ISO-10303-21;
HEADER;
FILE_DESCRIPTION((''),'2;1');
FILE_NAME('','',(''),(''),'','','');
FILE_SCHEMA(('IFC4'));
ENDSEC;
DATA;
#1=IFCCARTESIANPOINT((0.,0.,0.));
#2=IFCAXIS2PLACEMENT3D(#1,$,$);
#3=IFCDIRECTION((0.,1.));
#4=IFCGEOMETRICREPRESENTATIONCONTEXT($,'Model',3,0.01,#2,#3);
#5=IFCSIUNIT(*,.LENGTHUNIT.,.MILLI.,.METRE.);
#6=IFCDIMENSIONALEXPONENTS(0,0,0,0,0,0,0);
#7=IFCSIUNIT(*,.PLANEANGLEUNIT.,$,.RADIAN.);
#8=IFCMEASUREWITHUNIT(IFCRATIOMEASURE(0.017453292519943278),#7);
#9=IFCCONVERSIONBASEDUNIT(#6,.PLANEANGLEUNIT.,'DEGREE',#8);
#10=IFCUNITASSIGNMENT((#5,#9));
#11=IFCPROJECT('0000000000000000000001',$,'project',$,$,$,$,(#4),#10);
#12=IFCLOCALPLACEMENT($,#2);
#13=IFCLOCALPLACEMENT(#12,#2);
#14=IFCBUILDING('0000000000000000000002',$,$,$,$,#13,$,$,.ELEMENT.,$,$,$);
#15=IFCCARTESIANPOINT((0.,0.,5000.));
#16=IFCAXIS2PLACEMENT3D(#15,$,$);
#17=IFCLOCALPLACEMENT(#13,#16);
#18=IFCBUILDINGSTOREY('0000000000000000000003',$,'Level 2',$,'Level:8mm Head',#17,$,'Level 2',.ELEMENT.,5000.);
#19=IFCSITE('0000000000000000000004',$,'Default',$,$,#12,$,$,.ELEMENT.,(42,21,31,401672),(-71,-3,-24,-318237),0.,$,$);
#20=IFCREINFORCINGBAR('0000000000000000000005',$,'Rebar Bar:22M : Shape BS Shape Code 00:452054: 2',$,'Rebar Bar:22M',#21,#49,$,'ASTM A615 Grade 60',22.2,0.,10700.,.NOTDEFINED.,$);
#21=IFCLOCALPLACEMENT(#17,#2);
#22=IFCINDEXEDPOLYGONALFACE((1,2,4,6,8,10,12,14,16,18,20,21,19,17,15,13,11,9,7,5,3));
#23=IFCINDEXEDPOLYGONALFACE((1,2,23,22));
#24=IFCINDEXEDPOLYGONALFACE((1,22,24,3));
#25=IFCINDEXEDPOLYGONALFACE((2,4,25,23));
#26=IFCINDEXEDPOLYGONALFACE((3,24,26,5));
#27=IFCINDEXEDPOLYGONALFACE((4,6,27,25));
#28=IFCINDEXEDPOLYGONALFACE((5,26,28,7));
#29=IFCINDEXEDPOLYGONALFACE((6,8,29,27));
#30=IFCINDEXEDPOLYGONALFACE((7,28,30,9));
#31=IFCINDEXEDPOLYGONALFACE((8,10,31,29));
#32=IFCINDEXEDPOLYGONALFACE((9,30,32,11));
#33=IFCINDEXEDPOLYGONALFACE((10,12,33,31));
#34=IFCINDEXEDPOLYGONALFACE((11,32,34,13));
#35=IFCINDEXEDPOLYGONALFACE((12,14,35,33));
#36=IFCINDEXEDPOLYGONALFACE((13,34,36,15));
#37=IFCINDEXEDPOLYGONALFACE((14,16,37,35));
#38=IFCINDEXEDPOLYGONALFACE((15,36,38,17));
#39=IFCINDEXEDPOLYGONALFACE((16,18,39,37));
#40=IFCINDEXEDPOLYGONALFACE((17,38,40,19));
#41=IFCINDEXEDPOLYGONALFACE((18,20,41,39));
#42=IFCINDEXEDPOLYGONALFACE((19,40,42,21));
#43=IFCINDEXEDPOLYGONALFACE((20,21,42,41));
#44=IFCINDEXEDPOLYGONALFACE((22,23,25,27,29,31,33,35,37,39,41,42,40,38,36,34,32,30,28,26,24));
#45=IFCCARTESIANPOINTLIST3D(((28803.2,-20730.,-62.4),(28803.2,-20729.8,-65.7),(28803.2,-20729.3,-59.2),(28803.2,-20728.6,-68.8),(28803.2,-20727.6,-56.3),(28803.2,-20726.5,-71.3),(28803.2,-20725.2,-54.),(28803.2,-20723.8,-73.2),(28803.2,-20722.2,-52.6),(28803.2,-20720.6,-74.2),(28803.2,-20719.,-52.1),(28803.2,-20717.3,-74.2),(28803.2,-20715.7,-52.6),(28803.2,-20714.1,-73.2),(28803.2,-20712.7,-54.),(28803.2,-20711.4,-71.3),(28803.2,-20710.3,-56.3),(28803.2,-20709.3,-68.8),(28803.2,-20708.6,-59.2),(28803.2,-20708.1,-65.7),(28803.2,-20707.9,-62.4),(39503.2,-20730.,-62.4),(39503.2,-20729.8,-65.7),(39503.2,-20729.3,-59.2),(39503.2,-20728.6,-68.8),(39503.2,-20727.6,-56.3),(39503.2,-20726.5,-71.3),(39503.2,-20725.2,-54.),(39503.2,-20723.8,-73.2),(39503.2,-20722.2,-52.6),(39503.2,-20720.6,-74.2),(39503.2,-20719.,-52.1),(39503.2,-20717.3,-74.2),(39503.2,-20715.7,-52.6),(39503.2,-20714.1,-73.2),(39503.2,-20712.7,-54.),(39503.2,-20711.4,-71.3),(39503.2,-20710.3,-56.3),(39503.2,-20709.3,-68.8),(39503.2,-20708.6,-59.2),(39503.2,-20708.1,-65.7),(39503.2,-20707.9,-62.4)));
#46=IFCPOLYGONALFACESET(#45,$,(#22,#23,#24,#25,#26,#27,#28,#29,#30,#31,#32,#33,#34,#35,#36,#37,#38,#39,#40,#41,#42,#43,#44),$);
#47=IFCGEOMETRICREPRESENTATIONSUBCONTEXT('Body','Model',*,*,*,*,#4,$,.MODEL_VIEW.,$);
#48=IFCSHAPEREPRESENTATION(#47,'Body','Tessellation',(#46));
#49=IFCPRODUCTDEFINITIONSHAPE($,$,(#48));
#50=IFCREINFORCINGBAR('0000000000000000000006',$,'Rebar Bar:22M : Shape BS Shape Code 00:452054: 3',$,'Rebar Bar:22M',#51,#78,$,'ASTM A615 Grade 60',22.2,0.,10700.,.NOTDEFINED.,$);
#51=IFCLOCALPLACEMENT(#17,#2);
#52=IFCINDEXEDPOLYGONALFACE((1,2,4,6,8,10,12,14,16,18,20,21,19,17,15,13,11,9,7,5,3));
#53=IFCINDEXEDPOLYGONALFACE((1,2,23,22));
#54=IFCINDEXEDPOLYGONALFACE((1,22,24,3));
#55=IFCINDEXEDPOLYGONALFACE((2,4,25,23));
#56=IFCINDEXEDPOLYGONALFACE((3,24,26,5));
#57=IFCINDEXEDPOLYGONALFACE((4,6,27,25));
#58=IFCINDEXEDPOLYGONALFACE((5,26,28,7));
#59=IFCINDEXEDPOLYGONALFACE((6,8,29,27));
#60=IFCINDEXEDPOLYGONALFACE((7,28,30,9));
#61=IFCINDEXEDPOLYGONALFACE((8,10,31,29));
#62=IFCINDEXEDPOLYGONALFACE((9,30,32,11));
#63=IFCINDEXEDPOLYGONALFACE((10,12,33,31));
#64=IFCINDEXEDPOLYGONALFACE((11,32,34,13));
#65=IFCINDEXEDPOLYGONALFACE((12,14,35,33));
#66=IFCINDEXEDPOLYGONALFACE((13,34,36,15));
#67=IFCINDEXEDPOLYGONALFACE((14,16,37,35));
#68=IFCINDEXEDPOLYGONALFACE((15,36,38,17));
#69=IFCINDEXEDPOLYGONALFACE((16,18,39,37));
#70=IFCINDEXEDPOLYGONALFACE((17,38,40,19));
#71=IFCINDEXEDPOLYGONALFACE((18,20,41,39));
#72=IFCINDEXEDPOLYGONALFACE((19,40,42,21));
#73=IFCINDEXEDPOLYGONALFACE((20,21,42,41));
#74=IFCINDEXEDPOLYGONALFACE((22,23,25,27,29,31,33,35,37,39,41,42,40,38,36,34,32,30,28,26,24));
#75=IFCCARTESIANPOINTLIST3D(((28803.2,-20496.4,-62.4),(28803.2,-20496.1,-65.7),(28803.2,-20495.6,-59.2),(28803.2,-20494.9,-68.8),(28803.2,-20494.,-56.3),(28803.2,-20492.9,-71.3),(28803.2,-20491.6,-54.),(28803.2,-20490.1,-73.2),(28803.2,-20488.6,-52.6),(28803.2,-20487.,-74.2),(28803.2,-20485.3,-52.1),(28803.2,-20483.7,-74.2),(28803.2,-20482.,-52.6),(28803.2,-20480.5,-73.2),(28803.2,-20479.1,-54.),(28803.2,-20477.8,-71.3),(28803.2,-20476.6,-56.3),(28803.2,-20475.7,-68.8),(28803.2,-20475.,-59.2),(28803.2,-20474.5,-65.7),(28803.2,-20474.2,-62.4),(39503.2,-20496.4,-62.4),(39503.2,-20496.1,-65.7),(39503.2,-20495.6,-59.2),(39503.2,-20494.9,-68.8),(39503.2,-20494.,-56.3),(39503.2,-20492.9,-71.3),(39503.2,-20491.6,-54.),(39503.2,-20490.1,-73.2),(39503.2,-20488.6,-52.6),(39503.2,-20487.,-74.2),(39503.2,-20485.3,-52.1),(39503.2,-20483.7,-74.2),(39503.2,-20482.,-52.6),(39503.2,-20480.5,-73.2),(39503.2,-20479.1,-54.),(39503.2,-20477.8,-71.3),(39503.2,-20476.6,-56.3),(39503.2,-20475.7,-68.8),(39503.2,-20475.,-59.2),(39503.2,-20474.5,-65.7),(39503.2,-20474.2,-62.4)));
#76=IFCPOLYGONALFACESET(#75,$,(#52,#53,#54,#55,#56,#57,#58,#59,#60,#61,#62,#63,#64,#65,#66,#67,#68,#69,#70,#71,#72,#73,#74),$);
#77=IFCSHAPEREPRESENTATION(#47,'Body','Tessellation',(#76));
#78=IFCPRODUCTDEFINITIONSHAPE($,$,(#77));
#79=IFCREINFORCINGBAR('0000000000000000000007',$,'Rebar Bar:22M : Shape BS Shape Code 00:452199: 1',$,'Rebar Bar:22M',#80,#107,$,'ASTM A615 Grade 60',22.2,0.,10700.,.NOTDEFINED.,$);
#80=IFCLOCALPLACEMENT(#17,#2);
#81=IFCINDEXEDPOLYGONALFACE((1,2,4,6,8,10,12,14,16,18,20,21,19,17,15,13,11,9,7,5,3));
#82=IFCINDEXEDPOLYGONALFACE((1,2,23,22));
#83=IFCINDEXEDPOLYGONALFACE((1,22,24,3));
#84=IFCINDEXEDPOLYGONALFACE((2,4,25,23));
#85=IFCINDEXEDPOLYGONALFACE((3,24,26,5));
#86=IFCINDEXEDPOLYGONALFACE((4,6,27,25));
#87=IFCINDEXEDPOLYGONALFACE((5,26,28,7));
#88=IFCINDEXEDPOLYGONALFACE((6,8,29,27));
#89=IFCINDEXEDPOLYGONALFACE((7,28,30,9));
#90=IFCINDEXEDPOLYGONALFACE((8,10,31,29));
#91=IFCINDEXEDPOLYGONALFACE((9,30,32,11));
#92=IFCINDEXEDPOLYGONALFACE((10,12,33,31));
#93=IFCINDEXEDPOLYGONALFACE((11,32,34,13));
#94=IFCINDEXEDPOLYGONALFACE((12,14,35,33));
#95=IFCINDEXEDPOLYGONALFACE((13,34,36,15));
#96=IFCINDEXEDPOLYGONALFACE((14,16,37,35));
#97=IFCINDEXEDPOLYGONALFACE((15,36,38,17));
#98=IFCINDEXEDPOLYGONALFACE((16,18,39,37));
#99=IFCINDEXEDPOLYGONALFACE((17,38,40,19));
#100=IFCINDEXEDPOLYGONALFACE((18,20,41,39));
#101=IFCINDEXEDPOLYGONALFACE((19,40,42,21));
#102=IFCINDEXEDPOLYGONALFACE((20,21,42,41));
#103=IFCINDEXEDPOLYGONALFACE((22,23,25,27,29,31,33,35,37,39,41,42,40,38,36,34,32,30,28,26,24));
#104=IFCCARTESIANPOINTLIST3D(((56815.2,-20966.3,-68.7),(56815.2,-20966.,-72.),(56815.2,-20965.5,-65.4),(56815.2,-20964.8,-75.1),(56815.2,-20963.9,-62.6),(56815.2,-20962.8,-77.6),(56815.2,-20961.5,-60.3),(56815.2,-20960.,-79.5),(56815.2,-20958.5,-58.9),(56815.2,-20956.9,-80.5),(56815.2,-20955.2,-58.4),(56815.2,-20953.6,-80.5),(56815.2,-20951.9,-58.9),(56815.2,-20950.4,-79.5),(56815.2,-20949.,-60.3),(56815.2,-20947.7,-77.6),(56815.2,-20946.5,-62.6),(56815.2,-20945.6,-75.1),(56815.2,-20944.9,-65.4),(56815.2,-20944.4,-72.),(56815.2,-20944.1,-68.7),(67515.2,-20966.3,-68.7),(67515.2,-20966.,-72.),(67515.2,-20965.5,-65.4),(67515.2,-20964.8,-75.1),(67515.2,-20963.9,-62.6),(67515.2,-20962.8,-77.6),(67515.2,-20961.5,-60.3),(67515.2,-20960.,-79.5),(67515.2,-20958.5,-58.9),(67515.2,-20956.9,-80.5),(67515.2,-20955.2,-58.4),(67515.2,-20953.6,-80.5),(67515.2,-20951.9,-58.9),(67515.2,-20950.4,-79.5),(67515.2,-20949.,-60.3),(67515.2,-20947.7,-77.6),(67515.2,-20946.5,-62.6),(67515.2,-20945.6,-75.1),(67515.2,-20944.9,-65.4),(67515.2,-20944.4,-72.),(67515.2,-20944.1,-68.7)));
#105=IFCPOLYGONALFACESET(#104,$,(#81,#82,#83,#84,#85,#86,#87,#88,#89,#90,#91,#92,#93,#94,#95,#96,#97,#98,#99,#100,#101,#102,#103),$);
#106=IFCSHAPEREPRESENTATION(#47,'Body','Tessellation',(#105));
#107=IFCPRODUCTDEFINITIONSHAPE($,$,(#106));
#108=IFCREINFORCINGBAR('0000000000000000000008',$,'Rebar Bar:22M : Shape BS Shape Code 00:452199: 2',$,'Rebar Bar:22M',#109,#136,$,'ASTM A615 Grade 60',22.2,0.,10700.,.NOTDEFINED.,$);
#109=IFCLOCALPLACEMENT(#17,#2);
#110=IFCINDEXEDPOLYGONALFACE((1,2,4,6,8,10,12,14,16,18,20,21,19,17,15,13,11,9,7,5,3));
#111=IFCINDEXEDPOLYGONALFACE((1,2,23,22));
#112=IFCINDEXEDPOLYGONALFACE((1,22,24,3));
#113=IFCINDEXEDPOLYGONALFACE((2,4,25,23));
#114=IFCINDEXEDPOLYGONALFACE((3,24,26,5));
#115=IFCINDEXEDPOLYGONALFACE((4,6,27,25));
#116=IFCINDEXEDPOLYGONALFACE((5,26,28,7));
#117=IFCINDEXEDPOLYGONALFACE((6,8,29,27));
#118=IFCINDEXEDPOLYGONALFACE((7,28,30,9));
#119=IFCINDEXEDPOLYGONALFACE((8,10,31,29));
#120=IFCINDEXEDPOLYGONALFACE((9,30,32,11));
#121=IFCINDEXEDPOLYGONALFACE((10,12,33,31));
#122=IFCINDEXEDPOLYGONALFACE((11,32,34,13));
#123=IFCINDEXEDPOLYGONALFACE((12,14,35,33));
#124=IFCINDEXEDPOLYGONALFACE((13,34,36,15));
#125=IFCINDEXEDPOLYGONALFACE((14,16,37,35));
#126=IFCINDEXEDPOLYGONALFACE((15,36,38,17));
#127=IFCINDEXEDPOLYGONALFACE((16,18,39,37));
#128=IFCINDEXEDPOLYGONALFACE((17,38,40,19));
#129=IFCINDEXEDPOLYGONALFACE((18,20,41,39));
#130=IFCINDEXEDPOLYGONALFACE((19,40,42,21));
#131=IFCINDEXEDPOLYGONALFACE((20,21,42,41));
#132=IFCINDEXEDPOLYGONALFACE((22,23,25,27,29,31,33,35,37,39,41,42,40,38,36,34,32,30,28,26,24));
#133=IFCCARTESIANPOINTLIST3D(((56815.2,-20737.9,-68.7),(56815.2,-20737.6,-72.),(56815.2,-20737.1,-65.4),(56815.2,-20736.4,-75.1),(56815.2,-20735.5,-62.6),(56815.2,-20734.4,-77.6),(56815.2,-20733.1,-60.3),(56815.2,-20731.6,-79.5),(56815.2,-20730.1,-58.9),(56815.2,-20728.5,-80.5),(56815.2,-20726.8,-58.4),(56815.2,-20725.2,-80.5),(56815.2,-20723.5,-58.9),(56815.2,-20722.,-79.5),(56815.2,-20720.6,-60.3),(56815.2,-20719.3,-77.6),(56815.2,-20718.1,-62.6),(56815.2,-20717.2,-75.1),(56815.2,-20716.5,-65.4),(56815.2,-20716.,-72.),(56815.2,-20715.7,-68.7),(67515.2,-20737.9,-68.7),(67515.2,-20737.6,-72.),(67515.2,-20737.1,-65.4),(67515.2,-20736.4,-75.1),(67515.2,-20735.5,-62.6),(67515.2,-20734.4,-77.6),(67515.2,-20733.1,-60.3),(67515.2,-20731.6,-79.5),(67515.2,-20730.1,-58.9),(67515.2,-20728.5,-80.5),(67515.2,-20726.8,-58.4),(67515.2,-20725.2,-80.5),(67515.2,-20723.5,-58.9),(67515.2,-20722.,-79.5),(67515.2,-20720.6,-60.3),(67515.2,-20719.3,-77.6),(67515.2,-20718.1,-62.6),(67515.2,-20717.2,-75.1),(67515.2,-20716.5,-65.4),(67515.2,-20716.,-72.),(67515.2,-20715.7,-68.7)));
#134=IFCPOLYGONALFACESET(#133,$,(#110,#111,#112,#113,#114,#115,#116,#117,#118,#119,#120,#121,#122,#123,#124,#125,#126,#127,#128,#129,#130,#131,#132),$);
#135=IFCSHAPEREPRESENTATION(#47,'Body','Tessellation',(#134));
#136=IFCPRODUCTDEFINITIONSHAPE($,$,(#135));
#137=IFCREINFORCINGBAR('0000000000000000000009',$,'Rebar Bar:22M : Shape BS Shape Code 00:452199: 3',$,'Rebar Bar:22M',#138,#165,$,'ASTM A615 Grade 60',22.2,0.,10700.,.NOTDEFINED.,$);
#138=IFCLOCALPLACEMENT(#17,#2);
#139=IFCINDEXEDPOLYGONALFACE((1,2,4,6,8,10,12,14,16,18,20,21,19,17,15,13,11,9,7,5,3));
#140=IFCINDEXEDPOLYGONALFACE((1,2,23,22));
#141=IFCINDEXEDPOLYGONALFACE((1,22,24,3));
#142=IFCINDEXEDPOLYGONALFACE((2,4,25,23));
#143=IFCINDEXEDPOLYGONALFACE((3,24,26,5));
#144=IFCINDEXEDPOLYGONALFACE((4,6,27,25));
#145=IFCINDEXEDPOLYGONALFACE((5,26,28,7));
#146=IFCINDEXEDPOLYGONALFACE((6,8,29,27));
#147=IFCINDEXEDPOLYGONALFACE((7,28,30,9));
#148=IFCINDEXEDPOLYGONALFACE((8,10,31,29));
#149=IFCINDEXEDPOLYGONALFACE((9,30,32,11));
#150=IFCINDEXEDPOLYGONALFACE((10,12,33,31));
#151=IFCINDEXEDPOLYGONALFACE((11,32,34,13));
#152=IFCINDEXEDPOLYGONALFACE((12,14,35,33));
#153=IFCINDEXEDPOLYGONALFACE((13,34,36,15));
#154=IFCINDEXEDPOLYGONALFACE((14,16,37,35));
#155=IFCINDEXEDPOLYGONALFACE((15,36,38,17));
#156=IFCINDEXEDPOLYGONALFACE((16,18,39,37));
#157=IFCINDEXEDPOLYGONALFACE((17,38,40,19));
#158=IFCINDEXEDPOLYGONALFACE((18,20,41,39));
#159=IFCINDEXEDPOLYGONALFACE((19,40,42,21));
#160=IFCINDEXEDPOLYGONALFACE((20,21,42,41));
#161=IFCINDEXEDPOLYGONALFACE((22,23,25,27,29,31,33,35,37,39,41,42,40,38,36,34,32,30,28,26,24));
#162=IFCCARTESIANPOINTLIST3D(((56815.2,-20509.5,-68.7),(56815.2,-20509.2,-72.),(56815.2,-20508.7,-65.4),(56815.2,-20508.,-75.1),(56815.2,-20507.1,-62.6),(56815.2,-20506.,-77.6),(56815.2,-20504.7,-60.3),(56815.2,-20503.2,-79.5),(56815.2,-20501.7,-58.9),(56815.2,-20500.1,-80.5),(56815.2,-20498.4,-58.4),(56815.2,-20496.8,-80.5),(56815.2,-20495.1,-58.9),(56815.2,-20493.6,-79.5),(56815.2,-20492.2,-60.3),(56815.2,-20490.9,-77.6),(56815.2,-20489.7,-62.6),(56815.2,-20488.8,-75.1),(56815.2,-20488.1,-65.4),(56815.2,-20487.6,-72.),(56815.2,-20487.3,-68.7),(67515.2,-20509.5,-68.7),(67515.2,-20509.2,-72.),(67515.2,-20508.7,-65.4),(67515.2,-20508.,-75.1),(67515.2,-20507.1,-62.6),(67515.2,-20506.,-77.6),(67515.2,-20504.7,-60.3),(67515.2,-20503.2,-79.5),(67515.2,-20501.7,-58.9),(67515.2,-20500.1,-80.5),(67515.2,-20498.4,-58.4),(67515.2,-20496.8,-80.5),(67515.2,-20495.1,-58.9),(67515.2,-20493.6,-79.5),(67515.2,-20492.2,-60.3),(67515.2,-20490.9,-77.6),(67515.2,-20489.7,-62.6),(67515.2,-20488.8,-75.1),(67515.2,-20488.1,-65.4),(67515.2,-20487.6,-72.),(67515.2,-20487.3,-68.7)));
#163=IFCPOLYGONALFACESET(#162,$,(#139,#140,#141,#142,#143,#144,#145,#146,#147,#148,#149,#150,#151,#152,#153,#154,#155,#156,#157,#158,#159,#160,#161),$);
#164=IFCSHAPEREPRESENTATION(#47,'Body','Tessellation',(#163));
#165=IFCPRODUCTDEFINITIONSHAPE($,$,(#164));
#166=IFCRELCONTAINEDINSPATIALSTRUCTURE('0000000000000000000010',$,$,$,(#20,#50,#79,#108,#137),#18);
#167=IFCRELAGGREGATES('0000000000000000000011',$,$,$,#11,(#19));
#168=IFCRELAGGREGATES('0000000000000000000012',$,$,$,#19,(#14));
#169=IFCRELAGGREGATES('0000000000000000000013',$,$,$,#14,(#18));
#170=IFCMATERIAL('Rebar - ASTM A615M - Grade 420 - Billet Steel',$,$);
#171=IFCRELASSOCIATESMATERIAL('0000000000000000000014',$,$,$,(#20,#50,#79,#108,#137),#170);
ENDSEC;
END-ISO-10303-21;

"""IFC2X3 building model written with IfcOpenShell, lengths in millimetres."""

from ifc_helpers import new_model, entity, si_unit, converted_unit, direction, frame, origin, place, context, subcontext, project, spatial, material, element, save


model = new_model("IFC2X3")

# Units and contexts
model_context = context("Model", 3, precision=0.01, world=origin(), true_north=direction((0.0, 1.0)))
body_context = subcontext(model_context, "Body", "Model", "MODEL_VIEW")
ifc_project = project(units=[si_unit("LENGTHUNIT", "METRE", prefix="MILLI"), converted_unit("PLANEANGLEUNIT", "DEGREE", entity("IfcRatioMeasure", 0.017453292519943278), si_unit("PLANEANGLEUNIT", "RADIAN"), dimensions=[0, 0, 0, 0, 0, 0, 0])], contexts=[model_context])

# Site, building, storey
site_placement = place(None, origin())
site = spatial("IfcSite", under=ifc_project, at=site_placement, Name="Default", CompositionType="ELEMENT", RefLatitude=(42, 21, 31, 401672), RefLongitude=(-71, -3, -24, -318237), RefElevation=0.0)
building_placement = place(site_placement, origin())
building = spatial("IfcBuilding", under=site, at=building_placement, CompositionType="ELEMENT")
storey_placement = place(building_placement, frame((0.0, 0.0, 5000.0)))
storey = spatial("IfcBuildingStorey", under=building, at=storey_placement, Name="Level 2", ObjectType="Level:8mm Head", LongName="Level 2", CompositionType="ELEMENT", Elevation=5000.0)

# Reinforcing bars
ifc_material_1 = material(Name="Rebar - ASTM A615M - Grade 420 - Billet Steel")
reinforcing_bar_1_placement = place(storey_placement, origin())
element("IfcReinforcingBar", 1, at=reinforcing_bar_1_placement, inside=storey, material=ifc_material_1, Name="Rebar Bar:22M : Shape BS Shape Code 00:452054: 2", SteelGrade="ASTM A615 Grade 60", ObjectType="Rebar Bar:22M", BarLength=10700.0, BarRole="NOTDEFINED", CrossSectionArea=0.0, NominalDiameter=22.2, context=body_context, shape_type="AdvancedSweptSolid", body=[
    entity("IfcSweptDiskSolid", entity("IfcCompositeCurve", [entity("IfcCompositeCurveSegment", "CONTINUOUS", True, entity("IfcPolyline", [entity("IfcCartesianPoint", [28803.2, -20719.0, -63.2]), entity("IfcCartesianPoint", [39503.2, -20719.0, -63.2])]))], False), 11.1, None, 0.0, 1.0),
])
reinforcing_bar_2_placement = place(storey_placement, origin())
element("IfcReinforcingBar", 2, at=reinforcing_bar_2_placement, inside=storey, material=ifc_material_1, Name="Rebar Bar:22M : Shape BS Shape Code 00:452054: 3", SteelGrade="ASTM A615 Grade 60", ObjectType="Rebar Bar:22M", BarLength=10700.0, BarRole="NOTDEFINED", CrossSectionArea=0.0, NominalDiameter=22.2, context=body_context, shape_type="AdvancedSweptSolid", body=[
    entity("IfcSweptDiskSolid", entity("IfcCompositeCurve", [entity("IfcCompositeCurveSegment", "CONTINUOUS", True, entity("IfcPolyline", [entity("IfcCartesianPoint", [28803.2, -20485.3, -63.2]), entity("IfcCartesianPoint", [39503.2, -20485.3, -63.2])]))], False), 11.1, None, 0.0, 1.0),
])
reinforcing_bar_3_placement = place(storey_placement, origin())
element("IfcReinforcingBar", 3, at=reinforcing_bar_3_placement, inside=storey, material=ifc_material_1, Name="Rebar Bar:22M : Shape BS Shape Code 00:452199: 1", SteelGrade="ASTM A615 Grade 60", ObjectType="Rebar Bar:22M", BarLength=10700.0, BarRole="NOTDEFINED", CrossSectionArea=0.0, NominalDiameter=22.2, context=body_context, shape_type="AdvancedSweptSolid", body=[
    entity("IfcSweptDiskSolid", entity("IfcCompositeCurve", [entity("IfcCompositeCurveSegment", "CONTINUOUS", True, entity("IfcPolyline", [entity("IfcCartesianPoint", [56815.2, -20955.2, -69.5]), entity("IfcCartesianPoint", [67515.2, -20955.2, -69.5])]))], False), 11.1, None, 0.0, 1.0),
])
reinforcing_bar_4_placement = place(storey_placement, origin())
element("IfcReinforcingBar", 4, at=reinforcing_bar_4_placement, inside=storey, material=ifc_material_1, Name="Rebar Bar:22M : Shape BS Shape Code 00:452199: 2", SteelGrade="ASTM A615 Grade 60", ObjectType="Rebar Bar:22M", BarLength=10700.0, BarRole="NOTDEFINED", CrossSectionArea=0.0, NominalDiameter=22.2, context=body_context, shape_type="AdvancedSweptSolid", body=[
    entity("IfcSweptDiskSolid", entity("IfcCompositeCurve", [entity("IfcCompositeCurveSegment", "CONTINUOUS", True, entity("IfcPolyline", [entity("IfcCartesianPoint", [56815.2, -20726.8, -69.5]), entity("IfcCartesianPoint", [67515.2, -20726.8, -69.5])]))], False), 11.1, None, 0.0, 1.0),
])
reinforcing_bar_5_placement = place(storey_placement, origin())
element("IfcReinforcingBar", 5, at=reinforcing_bar_5_placement, inside=storey, material=ifc_material_1, Name="Rebar Bar:22M : Shape BS Shape Code 00:452199: 3", SteelGrade="ASTM A615 Grade 60", ObjectType="Rebar Bar:22M", BarLength=10700.0, BarRole="NOTDEFINED", CrossSectionArea=0.0, NominalDiameter=22.2, context=body_context, shape_type="AdvancedSweptSolid", body=[
    entity("IfcSweptDiskSolid", entity("IfcCompositeCurve", [entity("IfcCompositeCurveSegment", "CONTINUOUS", True, entity("IfcPolyline", [entity("IfcCartesianPoint", [56815.2, -20498.4, -69.5]), entity("IfcCartesianPoint", [67515.2, -20498.4, -69.5])]))], False), 11.1, None, 0.0, 1.0),
])

save(model, "model.ifc")
